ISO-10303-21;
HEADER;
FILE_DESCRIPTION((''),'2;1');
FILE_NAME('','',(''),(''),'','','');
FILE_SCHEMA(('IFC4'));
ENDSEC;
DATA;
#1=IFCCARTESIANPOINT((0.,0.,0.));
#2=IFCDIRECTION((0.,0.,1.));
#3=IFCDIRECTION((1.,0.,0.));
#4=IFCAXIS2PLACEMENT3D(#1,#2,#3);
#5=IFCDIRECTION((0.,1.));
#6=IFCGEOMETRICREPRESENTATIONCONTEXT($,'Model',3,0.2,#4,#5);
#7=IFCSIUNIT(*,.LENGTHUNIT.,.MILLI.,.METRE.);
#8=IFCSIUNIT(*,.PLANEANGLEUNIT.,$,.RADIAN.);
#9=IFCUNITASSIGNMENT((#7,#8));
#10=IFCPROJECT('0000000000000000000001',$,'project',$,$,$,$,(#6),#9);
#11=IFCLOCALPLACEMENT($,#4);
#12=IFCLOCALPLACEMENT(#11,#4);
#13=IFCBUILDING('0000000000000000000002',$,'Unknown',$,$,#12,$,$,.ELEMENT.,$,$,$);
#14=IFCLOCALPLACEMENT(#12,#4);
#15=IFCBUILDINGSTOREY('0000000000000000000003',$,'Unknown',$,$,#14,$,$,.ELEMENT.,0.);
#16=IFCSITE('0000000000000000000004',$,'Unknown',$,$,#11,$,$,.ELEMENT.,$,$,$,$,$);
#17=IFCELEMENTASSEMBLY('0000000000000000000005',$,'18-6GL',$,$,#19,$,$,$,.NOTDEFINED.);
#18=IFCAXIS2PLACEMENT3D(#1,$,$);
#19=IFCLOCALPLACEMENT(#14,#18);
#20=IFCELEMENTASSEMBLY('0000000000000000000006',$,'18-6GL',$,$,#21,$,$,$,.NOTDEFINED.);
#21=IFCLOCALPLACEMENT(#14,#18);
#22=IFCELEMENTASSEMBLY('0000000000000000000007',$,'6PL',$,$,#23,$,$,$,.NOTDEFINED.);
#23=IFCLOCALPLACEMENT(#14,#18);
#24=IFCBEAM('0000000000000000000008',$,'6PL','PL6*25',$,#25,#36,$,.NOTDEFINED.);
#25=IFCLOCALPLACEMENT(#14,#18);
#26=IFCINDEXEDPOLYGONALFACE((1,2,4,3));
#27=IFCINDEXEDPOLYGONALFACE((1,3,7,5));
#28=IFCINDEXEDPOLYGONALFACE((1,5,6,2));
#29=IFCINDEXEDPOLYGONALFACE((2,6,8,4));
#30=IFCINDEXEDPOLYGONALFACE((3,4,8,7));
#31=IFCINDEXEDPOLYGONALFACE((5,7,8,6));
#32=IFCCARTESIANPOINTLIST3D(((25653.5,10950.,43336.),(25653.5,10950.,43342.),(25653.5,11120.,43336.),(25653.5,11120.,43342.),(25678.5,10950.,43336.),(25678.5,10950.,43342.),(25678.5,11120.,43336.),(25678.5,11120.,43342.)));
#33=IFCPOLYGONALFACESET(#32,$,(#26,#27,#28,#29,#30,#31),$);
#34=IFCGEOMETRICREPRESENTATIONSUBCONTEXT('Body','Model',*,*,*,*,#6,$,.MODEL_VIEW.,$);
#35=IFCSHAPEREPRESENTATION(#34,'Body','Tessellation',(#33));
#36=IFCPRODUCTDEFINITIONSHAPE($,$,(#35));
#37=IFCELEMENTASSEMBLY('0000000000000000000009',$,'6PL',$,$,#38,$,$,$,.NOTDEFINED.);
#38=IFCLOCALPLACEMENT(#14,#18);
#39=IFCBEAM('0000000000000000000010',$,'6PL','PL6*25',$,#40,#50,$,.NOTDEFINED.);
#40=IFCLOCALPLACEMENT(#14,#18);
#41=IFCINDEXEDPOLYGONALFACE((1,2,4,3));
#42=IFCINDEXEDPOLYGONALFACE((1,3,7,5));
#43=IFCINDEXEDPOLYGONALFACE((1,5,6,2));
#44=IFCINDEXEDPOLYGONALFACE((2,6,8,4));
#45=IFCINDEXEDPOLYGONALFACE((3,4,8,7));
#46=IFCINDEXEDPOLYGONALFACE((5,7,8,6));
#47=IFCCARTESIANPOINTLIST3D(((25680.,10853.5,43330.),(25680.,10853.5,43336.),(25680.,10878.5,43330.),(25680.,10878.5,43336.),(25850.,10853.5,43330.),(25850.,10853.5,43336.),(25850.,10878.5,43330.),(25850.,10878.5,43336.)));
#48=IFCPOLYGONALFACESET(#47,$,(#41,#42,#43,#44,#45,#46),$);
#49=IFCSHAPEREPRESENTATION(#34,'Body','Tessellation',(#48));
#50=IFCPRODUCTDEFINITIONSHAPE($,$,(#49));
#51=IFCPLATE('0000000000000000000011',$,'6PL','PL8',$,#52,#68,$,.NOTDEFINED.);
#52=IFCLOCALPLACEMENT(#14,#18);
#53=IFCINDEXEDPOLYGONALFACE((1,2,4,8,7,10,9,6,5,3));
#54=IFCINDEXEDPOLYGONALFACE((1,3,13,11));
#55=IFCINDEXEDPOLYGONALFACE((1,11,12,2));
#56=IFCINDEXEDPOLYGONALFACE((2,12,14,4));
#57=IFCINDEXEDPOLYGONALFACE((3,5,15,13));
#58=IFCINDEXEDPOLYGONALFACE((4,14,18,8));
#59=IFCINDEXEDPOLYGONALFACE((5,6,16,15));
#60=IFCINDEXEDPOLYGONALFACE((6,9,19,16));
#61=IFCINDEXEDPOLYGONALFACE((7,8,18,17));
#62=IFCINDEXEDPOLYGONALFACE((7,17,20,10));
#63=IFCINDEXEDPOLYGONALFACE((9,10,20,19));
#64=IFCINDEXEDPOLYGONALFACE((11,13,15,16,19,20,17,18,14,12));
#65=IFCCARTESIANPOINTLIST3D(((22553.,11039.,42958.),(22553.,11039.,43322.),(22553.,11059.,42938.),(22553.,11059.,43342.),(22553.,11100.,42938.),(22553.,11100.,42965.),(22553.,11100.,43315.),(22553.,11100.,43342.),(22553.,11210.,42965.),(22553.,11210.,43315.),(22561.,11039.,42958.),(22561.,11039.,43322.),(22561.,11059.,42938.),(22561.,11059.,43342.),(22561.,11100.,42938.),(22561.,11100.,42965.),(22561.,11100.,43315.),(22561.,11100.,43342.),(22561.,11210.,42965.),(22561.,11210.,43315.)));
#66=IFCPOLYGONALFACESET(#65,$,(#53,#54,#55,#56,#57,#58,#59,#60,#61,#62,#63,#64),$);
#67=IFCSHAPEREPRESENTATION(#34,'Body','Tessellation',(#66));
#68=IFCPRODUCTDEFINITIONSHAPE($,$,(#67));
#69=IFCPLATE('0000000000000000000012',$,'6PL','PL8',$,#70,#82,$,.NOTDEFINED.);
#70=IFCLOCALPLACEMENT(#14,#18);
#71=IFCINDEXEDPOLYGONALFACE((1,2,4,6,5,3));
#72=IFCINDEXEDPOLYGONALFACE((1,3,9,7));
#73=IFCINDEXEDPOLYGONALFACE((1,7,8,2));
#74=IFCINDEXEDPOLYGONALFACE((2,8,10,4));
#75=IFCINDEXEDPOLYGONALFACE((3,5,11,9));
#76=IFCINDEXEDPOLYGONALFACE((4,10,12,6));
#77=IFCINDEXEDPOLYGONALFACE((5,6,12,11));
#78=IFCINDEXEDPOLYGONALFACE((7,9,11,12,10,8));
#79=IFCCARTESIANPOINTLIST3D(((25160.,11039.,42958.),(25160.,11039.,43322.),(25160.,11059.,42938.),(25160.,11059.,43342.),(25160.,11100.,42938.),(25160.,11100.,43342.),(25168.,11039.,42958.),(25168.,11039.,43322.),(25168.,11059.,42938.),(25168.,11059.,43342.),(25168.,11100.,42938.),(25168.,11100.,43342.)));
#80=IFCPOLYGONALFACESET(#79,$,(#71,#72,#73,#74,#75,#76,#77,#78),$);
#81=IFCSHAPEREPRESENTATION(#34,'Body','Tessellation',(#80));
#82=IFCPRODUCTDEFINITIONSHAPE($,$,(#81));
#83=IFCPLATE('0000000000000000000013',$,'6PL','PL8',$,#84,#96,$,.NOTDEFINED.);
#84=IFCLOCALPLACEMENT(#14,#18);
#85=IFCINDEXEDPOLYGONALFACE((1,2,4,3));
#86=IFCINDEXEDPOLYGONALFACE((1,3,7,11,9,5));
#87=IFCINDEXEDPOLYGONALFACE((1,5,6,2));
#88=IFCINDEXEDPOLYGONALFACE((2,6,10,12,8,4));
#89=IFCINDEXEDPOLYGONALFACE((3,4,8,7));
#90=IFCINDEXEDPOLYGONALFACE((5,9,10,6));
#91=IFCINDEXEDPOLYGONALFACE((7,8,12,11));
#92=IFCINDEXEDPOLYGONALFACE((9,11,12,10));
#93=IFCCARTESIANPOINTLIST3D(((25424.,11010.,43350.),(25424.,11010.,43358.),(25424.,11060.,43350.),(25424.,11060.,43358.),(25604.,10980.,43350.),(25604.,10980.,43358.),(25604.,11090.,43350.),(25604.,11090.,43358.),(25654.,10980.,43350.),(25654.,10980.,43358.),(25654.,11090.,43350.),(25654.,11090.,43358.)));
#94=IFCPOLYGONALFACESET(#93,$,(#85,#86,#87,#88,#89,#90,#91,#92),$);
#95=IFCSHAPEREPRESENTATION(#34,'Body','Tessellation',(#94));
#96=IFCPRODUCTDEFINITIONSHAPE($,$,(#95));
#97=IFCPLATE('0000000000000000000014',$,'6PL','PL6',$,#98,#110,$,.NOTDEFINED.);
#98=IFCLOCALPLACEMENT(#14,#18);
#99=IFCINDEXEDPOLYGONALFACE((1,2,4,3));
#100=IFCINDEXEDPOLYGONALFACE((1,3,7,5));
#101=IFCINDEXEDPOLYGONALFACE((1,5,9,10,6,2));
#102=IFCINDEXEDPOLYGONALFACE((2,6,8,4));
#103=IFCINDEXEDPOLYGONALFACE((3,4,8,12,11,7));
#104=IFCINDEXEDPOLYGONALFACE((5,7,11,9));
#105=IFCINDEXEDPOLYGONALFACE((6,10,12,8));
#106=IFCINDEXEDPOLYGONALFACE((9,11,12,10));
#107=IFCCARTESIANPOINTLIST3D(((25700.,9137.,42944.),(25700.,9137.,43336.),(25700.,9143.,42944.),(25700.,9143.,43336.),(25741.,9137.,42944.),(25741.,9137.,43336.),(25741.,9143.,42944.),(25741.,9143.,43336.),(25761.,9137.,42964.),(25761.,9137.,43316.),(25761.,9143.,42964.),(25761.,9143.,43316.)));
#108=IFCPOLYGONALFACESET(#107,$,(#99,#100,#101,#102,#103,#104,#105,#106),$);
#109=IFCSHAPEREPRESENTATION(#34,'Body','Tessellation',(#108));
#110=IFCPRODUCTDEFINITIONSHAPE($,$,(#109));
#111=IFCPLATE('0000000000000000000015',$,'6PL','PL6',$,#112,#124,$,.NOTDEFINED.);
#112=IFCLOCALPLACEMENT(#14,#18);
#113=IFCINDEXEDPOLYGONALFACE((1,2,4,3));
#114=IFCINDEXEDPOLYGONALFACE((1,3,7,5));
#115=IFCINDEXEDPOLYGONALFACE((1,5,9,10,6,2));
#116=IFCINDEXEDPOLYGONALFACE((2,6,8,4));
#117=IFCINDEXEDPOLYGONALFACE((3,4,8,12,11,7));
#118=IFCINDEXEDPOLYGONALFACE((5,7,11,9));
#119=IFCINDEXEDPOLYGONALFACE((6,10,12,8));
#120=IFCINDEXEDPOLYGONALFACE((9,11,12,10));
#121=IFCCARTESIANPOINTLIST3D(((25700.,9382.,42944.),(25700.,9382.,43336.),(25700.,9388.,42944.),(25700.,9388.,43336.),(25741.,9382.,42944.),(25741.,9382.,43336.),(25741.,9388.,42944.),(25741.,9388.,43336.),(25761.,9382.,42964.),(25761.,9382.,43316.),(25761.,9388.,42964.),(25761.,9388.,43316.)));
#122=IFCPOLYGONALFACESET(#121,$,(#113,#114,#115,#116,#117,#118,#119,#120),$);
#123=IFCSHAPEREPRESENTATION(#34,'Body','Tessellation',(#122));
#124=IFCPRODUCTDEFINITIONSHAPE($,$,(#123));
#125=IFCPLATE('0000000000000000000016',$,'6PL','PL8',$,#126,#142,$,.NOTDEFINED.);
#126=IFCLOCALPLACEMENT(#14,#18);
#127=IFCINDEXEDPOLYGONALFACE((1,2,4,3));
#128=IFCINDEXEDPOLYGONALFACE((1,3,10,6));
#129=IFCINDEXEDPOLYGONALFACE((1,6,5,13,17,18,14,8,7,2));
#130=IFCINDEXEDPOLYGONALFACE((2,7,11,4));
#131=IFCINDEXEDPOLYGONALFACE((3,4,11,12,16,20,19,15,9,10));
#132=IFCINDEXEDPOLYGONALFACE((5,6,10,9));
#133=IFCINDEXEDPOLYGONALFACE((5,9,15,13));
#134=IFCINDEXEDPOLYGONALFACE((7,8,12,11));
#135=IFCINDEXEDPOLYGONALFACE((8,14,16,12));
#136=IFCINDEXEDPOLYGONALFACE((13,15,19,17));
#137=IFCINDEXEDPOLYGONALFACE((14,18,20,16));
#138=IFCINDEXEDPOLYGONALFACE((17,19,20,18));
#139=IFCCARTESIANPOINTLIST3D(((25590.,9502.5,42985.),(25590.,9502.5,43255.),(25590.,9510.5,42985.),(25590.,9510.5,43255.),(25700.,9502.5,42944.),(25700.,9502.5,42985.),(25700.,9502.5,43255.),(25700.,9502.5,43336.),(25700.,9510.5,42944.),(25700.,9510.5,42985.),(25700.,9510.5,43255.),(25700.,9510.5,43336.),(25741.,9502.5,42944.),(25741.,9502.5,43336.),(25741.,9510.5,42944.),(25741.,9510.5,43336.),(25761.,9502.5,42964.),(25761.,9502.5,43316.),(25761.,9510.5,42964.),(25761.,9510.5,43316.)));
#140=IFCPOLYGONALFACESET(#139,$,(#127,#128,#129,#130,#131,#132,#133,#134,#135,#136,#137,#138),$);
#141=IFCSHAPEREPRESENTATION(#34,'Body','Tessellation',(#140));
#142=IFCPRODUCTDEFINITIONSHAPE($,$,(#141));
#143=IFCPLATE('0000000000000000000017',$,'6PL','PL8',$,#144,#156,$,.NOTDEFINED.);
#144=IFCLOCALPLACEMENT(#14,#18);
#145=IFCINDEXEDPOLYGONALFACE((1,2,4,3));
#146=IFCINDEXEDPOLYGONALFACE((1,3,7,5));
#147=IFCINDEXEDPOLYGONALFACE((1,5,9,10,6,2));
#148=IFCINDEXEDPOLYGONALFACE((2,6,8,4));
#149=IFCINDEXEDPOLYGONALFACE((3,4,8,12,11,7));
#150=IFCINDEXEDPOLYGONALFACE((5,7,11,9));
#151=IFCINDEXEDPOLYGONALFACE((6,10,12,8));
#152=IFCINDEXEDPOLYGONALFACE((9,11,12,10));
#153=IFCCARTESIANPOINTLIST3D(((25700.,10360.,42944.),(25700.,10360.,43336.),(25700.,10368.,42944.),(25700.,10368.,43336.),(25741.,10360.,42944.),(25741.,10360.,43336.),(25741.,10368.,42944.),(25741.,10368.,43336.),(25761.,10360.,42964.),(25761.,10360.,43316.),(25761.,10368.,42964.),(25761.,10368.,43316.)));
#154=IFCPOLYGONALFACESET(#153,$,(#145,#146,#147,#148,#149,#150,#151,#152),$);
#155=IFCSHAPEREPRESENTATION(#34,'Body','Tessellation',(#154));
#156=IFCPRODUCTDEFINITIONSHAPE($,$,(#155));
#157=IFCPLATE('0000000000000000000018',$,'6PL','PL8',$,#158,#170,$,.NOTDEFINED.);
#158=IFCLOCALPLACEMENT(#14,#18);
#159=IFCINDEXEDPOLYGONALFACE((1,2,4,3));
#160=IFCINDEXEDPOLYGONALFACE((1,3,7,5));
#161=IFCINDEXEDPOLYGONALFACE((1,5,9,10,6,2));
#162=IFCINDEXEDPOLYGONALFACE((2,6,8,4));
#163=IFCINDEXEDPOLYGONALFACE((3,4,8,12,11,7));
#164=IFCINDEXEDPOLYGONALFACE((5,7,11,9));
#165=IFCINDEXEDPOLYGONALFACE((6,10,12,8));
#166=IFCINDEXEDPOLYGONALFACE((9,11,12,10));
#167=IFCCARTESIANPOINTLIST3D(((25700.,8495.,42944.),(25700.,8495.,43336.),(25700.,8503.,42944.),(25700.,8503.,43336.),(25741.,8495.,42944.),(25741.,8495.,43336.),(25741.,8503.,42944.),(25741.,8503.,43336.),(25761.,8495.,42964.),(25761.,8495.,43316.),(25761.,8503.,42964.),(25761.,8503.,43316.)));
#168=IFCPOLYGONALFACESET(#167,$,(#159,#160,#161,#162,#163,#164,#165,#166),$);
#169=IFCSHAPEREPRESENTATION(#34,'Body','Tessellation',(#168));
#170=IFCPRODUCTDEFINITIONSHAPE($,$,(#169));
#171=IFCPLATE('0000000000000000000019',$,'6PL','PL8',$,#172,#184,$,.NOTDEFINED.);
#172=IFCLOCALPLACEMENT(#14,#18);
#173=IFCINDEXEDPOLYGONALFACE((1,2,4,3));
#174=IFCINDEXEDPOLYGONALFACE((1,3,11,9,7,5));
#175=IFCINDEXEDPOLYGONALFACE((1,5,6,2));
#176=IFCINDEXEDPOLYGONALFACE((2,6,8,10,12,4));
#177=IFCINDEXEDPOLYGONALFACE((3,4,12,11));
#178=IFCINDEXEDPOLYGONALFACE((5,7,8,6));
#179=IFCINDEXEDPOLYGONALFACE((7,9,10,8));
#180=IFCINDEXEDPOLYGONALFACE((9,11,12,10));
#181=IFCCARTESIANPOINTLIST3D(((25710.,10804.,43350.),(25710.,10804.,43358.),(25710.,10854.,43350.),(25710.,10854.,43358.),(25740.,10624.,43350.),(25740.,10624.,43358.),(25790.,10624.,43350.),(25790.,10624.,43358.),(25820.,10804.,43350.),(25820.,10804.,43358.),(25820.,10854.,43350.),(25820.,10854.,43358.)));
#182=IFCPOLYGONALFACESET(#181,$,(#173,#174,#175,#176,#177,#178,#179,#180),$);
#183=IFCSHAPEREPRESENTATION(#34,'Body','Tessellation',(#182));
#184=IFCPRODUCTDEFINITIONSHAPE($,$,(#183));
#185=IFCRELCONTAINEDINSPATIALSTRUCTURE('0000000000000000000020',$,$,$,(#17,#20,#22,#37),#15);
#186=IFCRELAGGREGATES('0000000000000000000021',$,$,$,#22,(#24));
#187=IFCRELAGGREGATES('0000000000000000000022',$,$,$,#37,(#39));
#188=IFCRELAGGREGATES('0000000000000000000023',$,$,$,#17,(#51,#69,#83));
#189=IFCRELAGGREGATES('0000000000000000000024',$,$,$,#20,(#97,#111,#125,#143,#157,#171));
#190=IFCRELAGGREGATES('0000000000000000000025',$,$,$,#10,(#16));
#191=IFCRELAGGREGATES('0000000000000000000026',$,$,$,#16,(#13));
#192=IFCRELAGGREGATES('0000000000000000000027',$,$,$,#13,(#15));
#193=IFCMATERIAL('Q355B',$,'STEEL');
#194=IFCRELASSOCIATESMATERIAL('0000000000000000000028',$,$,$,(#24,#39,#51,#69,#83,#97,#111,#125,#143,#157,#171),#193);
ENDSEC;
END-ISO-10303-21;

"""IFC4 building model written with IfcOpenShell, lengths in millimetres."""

from ifc_helpers import new_model, si_unit, direction, frame, origin_with_axes, place, context, subcontext, project, spatial, line, indexed_curve, outline, extrude, material, element, aggregate, save


model = new_model("IFC4")

# Units and contexts
model_context = context("Model", 3, precision=0.2, world=origin_with_axes(), true_north=direction((0.0, 1.0)))
body_context = subcontext(model_context, "Body", "Model", "MODEL_VIEW")
ifc_project = project(units=[si_unit("LENGTHUNIT", "METRE", prefix="MILLI"), si_unit("PLANEANGLEUNIT", "RADIAN")], contexts=[model_context])

# Site, building, storey
site_placement = place(None, origin_with_axes())
site = spatial("IfcSite", under=ifc_project, at=site_placement, Name="Unknown", CompositionType="ELEMENT")
building_placement = place(site_placement, origin_with_axes())
building = spatial("IfcBuilding", under=site, at=building_placement, Name="Unknown", CompositionType="ELEMENT")
storey_placement = place(building_placement, origin_with_axes())
storey = spatial("IfcBuildingStorey", under=building, at=storey_placement, Name="Unknown", CompositionType="ELEMENT", Elevation=0.0)

# Element assembly
assembly_1_placement = place(storey_placement, frame((21150.0, 11035.0, 43140.0), z_axis=(0.0, -1.0, 0.0), x_axis=(1.0, 0.0, 0.0)))
assembly_1 = element("IfcElementAssembly", 1, at=assembly_1_placement, inside=storey, Name="18-6GL", PredefinedType="NOTDEFINED")

# Element assembly
assembly_2_placement = place(storey_placement, frame((25765.0, 10900.0, 43140.0), z_axis=(-1.0, 0.0, 0.0), x_axis=(0.0, -1.0, 0.0)))
assembly_2 = element("IfcElementAssembly", 2, at=assembly_2_placement, inside=storey, Name="18-6GL", PredefinedType="NOTDEFINED")
ifc_material_1 = material(Name="Q355B", Category="STEEL")

# Element assemblies, beams
assembly_3_placement = place(storey_placement, frame((25666.0, 11120.0, 43339.0), z_axis=(0.0, 0.0, -1.0), x_axis=(0.0, -1.0, 0.0)))
assembly_3 = element("IfcElementAssembly", 3, at=assembly_3_placement, inside=storey, Name="6PL", PredefinedType="NOTDEFINED")
beam_1_placement = place(assembly_3_placement, origin_with_axes())
beam_1 = element("IfcBeam", 4, at=beam_1_placement, material=ifc_material_1, Name="6PL", Description="PL6*25", PredefinedType="NOTDEFINED", context=body_context, shape_type="SolidModel", body=[
    extrude(outline(indexed_curve([(-3.0, -12.5), (3.0, -12.5), (3.0, 12.5), (-3.0, 12.5)], segments=[line(1, 2, 3, 4, 1)])), frame((0.0, 0.0, 0.0), z_axis=(-1.0, 0.0, 0.0), x_axis=(0.0, 0.0, 1.0)), (0.0, 0.0, -1.0), 170.0),
])
aggregate(assembly_3, [beam_1])
assembly_4_placement = place(storey_placement, frame((25680.0, 10866.0, 43333.0), z_axis=(0.0, 0.0, -1.0), x_axis=(1.0, 0.0, 0.0)))
assembly_4 = element("IfcElementAssembly", 5, at=assembly_4_placement, inside=storey, Name="6PL", PredefinedType="NOTDEFINED")
beam_2_placement = place(assembly_4_placement, origin_with_axes())
beam_2 = element("IfcBeam", 6, at=beam_2_placement, material=ifc_material_1, Name="6PL", Description="PL6*25", PredefinedType="NOTDEFINED", context=body_context, shape_type="SolidModel", body=[
    extrude(outline(indexed_curve([(-3.0, -12.5), (3.0, -12.5), (3.0, 12.5), (-3.0, 12.5)], segments=[line(1, 2, 3, 4, 1)])), frame((0.0, 0.0, 0.0), z_axis=(-1.0, 0.0, 0.0), x_axis=(0.0, 0.0, 1.0)), (0.0, 0.0, -1.0), 170.0),
])
aggregate(assembly_4, [beam_2])

# Plates
plate_1_placement = place(assembly_1_placement, frame((1407.0, -182.0, -4.0), z_axis=(1.0, 0.0, 0.0), x_axis=(0.0, -0.707107, -0.707107)))
plate_1 = element("IfcPlate", 7, at=plate_1_placement, material=ifc_material_1, Name="6PL", Description="PL8", PredefinedType="NOTDEFINED", context=body_context, shape_type="SolidModel", body=[
    extrude(outline(indexed_curve([(0.0, 0.0), (28.3, 0.0), (57.3, 29.0), (38.2, 48.1), (116.0, 125.9), (-131.5, 373.4), (-209.3, 295.6), (-228.4, 314.7), (-257.4, 285.7), (-257.4, 257.4)], segments=[line(1, 2, 3, 4, 5, 6, 7, 8, 9, 10, 1)])), frame((0.0, 0.0, 4.0), z_axis=(0.0, 0.0, 1.0), x_axis=(1.0, 0.0, 0.0)), (0.0, 0.0, -1.0), 8.0),
])
plate_2_placement = place(assembly_1_placement, frame((4014.0, -202.0, -4.0), z_axis=(1.0, 0.0, 0.0), x_axis=(0.0, 0.0, -1.0)))
plate_2 = element("IfcPlate", 8, at=plate_2_placement, material=ifc_material_1, Name="6PL", Description="PL8", PredefinedType="NOTDEFINED", context=body_context, shape_type="SolidModel", body=[
    extrude(outline(indexed_curve([(0.0, 20.0), (20.0, 0.0), (61.0, 0.0), (61.0, 404.0), (20.0, 404.0), (0.0, 384.0)], segments=[line(1, 2, 3, 4, 5, 6, 1)])), frame((0.0, 0.0, 4.0), z_axis=(0.0, 0.0, 1.0), x_axis=(1.0, 0.0, 0.0)), (0.0, 0.0, -1.0), 8.0),
])
plate_3_placement = place(assembly_1_placement, frame((4454.0, 214.0, 55.0), z_axis=(0.0, 1.0, 0.0), x_axis=(1.0, 0.0, 0.0)))
plate_3 = element("IfcPlate", 9, at=plate_3_placement, material=ifc_material_1, Name="6PL", Description="PL8", PredefinedType="NOTDEFINED", context=body_context, shape_type="SolidModel", body=[
    extrude(outline(indexed_curve([(0.0, 0.0), (50.0, 0.0), (50.0, 110.0), (0.0, 110.0), (-180.0, 80.0), (-180.0, 30.0)], segments=[line(1, 2, 3, 4, 5, 6, 1)])), frame((0.0, 0.0, 4.0), z_axis=(0.0, 0.0, 1.0), x_axis=(1.0, 0.0, 0.0)), (0.0, 0.0, -1.0), 8.0),
])
aggregate(assembly_1, [plate_1, plate_2, plate_3])
plate_4_placement = place(assembly_2_placement, frame((1760.0, -196.0, 4.0), z_axis=(-1.0, 0.0, 0.0), x_axis=(0.0, 0.0, 1.0)))
plate_4 = element("IfcPlate", 10, at=plate_4_placement, material=ifc_material_1, Name="6PL", Description="PL6", PredefinedType="NOTDEFINED", context=body_context, shape_type="SolidModel", body=[
    extrude(outline(indexed_curve([(0.0, 20.0), (20.0, 0.0), (61.0, 0.0), (61.0, 392.0), (20.0, 392.0), (0.0, 372.0)], segments=[line(1, 2, 3, 4, 5, 6, 1)])), frame((0.0, 0.0, 3.0), z_axis=(0.0, 0.0, 1.0), x_axis=(1.0, 0.0, 0.0)), (0.0, 0.0, -1.0), 6.0),
])
plate_5_placement = place(assembly_2_placement, frame((1515.0, -196.0, 4.0), z_axis=(-1.0, 0.0, 0.0), x_axis=(0.0, 0.0, 1.0)))
plate_5 = element("IfcPlate", 11, at=plate_5_placement, material=ifc_material_1, Name="6PL", Description="PL6", PredefinedType="NOTDEFINED", context=body_context, shape_type="SolidModel", body=[
    extrude(outline(indexed_curve([(0.0, 20.0), (20.0, 0.0), (61.0, 0.0), (61.0, 392.0), (20.0, 392.0), (0.0, 372.0)], segments=[line(1, 2, 3, 4, 5, 6, 1)])), frame((0.0, 0.0, 3.0), z_axis=(0.0, 0.0, 1.0), x_axis=(1.0, 0.0, 0.0)), (0.0, 0.0, -1.0), 6.0),
])
plate_6_placement = place(assembly_2_placement, frame((1393.5, -176.0, 4.0), z_axis=(-1.0, 0.0, 0.0), x_axis=(0.0, -0.707107, 0.707107)))
plate_6 = element("IfcPlate", 12, at=plate_6_placement, material=ifc_material_1, Name="6PL", Description="PL8", PredefinedType="NOTDEFINED", context=body_context, shape_type="SolidModel", body=[
    extrude(outline(indexed_curve([(0.0, 0.0), (28.3, 0.0), (57.3, 29.0), (28.3, 58.0), (106.1, 135.8), (-84.9, 326.7), (-162.6, 248.9), (-219.9, 306.2), (-248.9, 277.2), (-248.9, 248.9)], segments=[line(1, 2, 3, 4, 5, 6, 7, 8, 9, 10, 1)])), frame((0.0, 0.0, 4.0), z_axis=(0.0, 0.0, 1.0), x_axis=(1.0, 0.0, 0.0)), (0.0, 0.0, -1.0), 8.0),
])
plate_7_placement = place(assembly_2_placement, frame((536.0, -196.0, 4.0), z_axis=(-1.0, 0.0, 0.0), x_axis=(0.0, 0.0, 1.0)))
plate_7 = element("IfcPlate", 13, at=plate_7_placement, material=ifc_material_1, Name="6PL", Description="PL8", PredefinedType="NOTDEFINED", context=body_context, shape_type="SolidModel", body=[
    extrude(outline(indexed_curve([(0.0, 20.0), (20.0, 0.0), (61.0, 0.0), (61.0, 392.0), (20.0, 392.0), (0.0, 372.0)], segments=[line(1, 2, 3, 4, 5, 6, 1)])), frame((0.0, 0.0, 4.0), z_axis=(0.0, 0.0, 1.0), x_axis=(1.0, 0.0, 0.0)), (0.0, 0.0, -1.0), 8.0),
])
plate_8_placement = place(assembly_2_placement, frame((2401.0, -196.0, 4.0), z_axis=(-1.0, 0.0, 0.0), x_axis=(0.0, 0.0, 1.0)))
plate_8 = element("IfcPlate", 14, at=plate_8_placement, material=ifc_material_1, Name="6PL", Description="PL8", PredefinedType="NOTDEFINED", context=body_context, shape_type="SolidModel", body=[
    extrude(outline(indexed_curve([(0.0, 20.0), (20.0, 0.0), (61.0, 0.0), (61.0, 392.0), (20.0, 392.0), (0.0, 372.0)], segments=[line(1, 2, 3, 4, 5, 6, 1)])), frame((0.0, 0.0, 4.0), z_axis=(0.0, 0.0, 1.0), x_axis=(1.0, 0.0, 0.0)), (0.0, 0.0, -1.0), 8.0),
])
plate_9_placement = place(assembly_2_placement, frame((96.0, 214.0, -55.0), z_axis=(0.0, 1.0, 0.0), x_axis=(-1.0, 0.0, 0.0)))
plate_9 = element("IfcPlate", 15, at=plate_9_placement, material=ifc_material_1, Name="6PL", Description="PL8", PredefinedType="NOTDEFINED", context=body_context, shape_type="SolidModel", body=[
    extrude(outline(indexed_curve([(0.0, 0.0), (50.0, 0.0), (50.0, 110.0), (0.0, 110.0), (-180.0, 80.0), (-180.0, 30.0)], segments=[line(1, 2, 3, 4, 5, 6, 1)])), frame((0.0, 0.0, 4.0), z_axis=(0.0, 0.0, 1.0), x_axis=(1.0, 0.0, 0.0)), (0.0, 0.0, -1.0), 8.0),
])

aggregate(assembly_2, [plate_4, plate_5, plate_6, plate_7, plate_8, plate_9])

save(model, "model.ifc")
